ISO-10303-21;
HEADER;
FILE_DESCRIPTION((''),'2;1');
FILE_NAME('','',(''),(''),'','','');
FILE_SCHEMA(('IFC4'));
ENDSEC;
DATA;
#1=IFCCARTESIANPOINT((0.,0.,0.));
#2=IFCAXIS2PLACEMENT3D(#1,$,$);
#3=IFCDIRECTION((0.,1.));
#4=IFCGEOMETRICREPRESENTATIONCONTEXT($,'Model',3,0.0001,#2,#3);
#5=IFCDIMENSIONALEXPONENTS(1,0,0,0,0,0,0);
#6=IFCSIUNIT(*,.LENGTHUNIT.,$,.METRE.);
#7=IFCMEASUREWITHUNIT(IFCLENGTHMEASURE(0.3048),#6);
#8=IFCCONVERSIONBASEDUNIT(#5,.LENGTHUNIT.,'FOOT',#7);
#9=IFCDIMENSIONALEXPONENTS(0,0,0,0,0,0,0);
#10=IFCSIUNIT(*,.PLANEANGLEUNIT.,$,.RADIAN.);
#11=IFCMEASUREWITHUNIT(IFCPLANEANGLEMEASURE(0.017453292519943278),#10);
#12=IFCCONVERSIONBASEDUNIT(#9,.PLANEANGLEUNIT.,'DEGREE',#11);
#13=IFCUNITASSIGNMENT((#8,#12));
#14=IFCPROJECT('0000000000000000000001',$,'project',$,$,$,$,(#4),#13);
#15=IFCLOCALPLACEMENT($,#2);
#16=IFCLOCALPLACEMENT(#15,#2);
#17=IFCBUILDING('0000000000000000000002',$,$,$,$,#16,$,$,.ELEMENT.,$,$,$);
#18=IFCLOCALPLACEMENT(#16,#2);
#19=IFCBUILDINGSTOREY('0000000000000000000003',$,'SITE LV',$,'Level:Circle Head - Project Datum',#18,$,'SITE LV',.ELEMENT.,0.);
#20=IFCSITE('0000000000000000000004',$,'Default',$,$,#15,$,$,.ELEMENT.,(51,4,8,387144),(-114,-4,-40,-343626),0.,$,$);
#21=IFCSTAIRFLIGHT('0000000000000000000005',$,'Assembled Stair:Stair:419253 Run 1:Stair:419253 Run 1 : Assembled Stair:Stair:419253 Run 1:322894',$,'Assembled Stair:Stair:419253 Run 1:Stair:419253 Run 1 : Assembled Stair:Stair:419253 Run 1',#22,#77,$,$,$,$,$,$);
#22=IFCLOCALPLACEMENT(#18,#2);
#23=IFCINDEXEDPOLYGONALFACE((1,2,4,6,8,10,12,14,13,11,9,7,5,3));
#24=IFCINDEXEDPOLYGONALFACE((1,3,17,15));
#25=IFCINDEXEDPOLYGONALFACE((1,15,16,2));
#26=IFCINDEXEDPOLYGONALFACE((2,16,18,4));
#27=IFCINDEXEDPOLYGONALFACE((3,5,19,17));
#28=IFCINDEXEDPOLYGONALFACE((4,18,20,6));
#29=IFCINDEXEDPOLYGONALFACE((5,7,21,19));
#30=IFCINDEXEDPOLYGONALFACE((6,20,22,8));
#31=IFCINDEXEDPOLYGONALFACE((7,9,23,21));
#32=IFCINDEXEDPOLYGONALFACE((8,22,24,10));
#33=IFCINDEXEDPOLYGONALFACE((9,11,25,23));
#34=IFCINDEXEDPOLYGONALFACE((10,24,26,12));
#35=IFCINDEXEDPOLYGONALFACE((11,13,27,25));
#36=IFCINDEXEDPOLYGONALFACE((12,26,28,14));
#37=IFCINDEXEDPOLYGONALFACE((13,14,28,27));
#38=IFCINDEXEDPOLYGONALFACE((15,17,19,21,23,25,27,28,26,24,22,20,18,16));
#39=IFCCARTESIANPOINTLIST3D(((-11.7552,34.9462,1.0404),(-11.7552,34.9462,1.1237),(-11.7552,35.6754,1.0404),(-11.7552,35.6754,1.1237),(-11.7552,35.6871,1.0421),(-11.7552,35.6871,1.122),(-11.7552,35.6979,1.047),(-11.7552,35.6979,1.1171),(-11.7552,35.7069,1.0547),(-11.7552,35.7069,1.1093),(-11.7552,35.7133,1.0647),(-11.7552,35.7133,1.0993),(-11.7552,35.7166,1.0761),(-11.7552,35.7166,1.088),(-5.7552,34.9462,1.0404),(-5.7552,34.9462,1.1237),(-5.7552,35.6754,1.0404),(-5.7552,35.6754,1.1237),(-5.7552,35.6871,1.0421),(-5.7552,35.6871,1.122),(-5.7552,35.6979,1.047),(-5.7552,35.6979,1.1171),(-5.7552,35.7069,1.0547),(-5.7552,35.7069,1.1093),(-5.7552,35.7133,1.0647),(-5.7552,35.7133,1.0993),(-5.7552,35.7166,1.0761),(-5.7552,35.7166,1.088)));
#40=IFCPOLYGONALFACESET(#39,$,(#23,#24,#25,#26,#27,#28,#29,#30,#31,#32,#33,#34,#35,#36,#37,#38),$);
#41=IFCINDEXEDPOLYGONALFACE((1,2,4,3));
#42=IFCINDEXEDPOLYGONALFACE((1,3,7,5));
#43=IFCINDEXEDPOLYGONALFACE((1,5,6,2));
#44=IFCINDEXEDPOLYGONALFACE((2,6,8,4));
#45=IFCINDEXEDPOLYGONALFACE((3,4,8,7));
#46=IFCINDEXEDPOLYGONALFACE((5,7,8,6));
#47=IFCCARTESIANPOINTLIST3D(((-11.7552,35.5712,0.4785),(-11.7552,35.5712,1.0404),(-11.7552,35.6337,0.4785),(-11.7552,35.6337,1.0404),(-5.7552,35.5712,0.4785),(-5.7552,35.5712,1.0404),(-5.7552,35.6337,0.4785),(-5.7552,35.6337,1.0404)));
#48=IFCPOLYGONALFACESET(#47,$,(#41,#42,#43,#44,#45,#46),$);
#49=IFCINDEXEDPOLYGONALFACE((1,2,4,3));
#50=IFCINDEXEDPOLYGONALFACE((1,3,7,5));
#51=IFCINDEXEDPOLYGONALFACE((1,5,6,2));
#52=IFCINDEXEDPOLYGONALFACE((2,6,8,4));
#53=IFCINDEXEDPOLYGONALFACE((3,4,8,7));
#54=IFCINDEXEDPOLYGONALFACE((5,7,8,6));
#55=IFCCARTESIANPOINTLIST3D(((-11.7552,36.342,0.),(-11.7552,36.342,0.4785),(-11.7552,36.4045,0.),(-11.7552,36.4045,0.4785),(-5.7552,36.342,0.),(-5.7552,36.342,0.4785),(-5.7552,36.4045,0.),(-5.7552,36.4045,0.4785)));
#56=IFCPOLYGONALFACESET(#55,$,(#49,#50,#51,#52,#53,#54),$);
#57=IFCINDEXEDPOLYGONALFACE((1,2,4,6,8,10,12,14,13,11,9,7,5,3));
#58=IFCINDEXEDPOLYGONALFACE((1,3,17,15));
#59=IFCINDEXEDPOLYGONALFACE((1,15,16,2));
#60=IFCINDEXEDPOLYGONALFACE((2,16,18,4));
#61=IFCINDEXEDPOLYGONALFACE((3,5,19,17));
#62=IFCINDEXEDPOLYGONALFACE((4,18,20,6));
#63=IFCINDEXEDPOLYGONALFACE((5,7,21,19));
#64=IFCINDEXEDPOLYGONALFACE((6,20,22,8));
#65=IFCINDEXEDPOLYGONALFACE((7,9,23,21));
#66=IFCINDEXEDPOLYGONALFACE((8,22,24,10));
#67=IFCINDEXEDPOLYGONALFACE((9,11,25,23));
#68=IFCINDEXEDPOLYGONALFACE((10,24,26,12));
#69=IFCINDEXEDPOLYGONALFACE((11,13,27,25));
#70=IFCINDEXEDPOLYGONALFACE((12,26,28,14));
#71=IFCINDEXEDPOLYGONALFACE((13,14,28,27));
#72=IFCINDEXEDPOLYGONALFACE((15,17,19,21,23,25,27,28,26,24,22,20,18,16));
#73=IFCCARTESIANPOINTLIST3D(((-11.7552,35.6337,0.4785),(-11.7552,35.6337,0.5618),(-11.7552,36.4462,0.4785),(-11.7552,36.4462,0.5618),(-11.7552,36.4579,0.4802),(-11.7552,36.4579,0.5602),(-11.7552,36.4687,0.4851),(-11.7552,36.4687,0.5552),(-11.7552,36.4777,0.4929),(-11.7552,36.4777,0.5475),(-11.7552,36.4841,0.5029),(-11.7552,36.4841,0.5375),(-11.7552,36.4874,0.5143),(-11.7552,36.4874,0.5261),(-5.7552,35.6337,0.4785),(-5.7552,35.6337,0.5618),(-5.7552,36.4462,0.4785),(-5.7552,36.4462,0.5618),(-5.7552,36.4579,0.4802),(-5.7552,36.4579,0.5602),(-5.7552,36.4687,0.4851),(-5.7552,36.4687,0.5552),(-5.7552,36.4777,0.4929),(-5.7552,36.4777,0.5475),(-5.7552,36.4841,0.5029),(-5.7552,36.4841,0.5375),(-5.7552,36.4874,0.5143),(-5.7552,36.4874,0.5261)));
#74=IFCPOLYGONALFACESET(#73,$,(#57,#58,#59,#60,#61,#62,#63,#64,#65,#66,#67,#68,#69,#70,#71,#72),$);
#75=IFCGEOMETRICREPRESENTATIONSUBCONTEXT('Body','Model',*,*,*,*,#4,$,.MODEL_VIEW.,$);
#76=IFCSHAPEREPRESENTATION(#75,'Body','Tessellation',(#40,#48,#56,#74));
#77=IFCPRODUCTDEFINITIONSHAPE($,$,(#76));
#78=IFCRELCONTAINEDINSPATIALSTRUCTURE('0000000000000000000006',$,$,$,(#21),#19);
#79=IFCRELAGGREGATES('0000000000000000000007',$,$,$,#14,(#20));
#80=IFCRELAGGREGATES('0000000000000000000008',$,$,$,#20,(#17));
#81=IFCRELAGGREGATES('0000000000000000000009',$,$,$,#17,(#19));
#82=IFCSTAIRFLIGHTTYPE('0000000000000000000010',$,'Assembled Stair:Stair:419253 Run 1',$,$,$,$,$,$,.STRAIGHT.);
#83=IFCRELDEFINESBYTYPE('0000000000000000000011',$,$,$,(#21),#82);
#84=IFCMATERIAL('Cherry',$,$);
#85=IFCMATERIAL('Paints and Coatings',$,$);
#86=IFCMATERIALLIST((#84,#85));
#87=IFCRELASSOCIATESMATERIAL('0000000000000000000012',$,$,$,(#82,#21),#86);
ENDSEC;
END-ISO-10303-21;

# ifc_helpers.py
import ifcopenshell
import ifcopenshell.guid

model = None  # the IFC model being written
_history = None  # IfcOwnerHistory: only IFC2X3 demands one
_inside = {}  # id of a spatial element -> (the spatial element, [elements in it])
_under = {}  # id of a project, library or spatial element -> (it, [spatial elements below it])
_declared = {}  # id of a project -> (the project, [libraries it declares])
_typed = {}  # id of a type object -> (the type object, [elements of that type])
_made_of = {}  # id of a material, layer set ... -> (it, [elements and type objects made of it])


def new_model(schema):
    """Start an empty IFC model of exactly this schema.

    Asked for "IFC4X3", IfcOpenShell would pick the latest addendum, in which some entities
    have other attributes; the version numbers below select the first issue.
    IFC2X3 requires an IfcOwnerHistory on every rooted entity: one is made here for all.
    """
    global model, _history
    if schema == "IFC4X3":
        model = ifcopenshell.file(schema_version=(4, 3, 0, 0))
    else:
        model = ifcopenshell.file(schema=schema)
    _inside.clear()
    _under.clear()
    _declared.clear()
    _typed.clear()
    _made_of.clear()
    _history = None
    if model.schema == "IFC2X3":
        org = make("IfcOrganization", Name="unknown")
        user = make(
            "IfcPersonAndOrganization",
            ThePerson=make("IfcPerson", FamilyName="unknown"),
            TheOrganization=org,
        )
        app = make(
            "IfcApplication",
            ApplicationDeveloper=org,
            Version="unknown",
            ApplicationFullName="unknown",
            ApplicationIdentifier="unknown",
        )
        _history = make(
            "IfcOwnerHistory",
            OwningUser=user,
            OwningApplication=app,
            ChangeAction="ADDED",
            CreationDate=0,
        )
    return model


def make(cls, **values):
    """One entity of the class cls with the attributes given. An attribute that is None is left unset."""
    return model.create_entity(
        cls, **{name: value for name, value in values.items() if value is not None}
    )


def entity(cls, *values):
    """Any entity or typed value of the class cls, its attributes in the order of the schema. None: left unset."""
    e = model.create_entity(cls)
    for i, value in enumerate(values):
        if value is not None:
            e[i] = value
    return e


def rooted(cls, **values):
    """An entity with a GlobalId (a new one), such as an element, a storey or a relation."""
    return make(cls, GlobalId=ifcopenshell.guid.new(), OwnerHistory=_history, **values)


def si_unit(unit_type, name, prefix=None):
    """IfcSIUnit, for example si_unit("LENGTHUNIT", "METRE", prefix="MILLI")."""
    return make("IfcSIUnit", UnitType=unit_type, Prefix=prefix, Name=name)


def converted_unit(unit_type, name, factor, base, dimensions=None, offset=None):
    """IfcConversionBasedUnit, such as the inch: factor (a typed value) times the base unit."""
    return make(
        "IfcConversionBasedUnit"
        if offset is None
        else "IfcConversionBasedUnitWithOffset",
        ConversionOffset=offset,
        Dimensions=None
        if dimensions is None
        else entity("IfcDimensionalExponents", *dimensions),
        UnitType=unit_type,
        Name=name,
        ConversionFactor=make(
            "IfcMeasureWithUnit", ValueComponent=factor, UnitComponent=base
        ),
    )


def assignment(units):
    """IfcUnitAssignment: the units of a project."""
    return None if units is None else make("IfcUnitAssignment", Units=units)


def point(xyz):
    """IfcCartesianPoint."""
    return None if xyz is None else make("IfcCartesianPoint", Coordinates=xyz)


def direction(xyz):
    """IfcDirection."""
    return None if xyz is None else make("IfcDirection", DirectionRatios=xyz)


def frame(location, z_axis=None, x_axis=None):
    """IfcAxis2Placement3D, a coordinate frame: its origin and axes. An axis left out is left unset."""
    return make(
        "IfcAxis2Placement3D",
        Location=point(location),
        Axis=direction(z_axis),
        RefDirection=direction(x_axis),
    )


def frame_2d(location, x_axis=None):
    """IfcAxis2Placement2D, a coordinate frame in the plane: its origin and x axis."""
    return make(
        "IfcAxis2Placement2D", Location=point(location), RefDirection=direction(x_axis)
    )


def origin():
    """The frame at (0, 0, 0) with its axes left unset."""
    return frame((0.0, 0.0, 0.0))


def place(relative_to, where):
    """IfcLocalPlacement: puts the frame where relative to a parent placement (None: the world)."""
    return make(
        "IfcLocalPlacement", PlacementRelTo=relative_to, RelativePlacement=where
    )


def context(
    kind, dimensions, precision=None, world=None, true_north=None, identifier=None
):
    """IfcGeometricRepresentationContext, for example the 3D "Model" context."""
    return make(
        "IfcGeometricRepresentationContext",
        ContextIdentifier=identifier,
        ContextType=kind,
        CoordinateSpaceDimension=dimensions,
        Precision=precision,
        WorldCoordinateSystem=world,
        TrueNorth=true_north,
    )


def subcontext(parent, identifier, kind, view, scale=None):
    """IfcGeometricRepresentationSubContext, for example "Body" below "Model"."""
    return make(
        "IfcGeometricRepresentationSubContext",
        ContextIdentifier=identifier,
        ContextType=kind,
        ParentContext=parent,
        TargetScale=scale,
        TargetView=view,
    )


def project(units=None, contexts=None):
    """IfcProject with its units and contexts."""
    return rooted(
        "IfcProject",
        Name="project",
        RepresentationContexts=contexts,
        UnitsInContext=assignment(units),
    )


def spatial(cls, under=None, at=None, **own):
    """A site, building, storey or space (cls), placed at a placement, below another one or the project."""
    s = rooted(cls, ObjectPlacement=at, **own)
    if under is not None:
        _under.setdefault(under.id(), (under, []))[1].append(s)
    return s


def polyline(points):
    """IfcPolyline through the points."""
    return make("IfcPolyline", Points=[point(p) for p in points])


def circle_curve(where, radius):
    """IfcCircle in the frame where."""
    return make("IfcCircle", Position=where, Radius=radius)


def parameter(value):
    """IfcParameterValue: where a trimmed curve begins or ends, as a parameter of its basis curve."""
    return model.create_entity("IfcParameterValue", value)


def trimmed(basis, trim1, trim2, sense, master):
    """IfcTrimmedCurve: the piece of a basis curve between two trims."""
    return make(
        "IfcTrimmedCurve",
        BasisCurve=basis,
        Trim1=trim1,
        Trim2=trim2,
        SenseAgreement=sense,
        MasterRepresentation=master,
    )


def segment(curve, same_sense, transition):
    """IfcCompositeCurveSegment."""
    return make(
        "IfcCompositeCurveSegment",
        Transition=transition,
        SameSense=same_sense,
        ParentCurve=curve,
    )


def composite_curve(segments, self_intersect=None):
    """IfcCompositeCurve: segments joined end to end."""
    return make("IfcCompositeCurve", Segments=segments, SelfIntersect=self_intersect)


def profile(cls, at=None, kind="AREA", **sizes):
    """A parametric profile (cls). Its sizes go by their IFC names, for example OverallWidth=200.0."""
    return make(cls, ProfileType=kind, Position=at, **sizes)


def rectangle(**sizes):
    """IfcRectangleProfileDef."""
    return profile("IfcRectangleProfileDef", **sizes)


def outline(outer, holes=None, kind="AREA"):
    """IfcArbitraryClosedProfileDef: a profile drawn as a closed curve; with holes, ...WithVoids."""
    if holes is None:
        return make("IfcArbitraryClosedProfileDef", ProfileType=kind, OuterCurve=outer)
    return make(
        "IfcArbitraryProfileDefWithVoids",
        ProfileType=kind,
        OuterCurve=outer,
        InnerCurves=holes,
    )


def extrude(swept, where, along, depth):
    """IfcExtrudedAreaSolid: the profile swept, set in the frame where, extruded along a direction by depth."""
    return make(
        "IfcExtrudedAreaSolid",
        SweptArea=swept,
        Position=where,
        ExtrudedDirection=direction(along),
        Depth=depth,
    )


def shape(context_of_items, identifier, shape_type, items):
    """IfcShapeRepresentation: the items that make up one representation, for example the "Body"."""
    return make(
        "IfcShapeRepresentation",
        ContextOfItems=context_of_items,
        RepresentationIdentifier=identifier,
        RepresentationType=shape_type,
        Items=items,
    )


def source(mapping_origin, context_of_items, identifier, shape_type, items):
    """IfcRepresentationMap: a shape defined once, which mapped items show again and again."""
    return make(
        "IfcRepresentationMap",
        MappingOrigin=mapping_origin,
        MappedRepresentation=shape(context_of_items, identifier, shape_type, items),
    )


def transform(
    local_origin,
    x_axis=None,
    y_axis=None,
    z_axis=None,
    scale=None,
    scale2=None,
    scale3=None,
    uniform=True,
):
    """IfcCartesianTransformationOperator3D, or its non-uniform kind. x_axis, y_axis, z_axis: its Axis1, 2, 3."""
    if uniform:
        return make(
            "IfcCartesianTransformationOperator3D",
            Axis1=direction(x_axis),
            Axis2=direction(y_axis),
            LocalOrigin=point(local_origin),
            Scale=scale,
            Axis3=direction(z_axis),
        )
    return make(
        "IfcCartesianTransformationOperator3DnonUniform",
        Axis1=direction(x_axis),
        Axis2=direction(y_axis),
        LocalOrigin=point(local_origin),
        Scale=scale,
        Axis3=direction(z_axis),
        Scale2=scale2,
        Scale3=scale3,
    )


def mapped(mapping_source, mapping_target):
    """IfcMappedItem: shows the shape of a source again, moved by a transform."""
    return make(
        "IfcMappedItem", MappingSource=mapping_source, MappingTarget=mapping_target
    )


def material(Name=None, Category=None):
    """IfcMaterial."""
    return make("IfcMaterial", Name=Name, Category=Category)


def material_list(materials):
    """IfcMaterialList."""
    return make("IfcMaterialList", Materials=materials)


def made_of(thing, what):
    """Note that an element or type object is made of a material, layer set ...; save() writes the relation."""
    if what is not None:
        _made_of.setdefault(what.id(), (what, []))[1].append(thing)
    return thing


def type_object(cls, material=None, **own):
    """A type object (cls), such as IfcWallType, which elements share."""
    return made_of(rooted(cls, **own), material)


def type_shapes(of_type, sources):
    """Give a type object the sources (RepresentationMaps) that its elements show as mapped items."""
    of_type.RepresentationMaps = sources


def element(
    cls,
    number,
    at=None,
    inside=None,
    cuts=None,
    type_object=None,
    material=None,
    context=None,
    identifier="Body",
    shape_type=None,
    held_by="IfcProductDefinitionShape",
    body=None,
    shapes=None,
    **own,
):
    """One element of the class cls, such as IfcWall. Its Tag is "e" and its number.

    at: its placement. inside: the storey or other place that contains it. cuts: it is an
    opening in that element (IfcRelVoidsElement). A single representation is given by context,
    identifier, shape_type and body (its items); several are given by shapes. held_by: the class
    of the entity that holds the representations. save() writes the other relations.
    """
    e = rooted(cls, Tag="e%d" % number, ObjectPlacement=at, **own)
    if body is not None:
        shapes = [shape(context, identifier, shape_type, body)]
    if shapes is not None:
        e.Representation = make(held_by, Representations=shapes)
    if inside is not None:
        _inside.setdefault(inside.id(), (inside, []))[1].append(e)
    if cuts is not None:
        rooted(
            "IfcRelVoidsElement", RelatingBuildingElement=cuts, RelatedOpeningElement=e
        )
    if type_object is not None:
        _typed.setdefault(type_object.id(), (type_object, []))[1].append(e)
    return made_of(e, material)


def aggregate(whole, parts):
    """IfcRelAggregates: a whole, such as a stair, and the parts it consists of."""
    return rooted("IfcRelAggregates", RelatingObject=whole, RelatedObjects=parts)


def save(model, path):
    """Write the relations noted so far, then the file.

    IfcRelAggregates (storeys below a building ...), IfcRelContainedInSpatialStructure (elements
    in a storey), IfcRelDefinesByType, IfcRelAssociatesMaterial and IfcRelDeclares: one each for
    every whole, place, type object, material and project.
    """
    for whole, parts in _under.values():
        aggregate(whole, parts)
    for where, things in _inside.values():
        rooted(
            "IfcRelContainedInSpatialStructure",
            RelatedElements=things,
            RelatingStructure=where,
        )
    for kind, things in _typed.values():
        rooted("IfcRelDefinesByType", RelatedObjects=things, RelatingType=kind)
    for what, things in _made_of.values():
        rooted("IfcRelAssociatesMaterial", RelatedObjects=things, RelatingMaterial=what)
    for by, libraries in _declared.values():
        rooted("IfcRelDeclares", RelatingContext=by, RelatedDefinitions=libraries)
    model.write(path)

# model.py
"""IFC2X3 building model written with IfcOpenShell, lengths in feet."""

from ifc_helpers import new_model, entity, si_unit, converted_unit, direction, frame, frame_2d, origin, place, context, subcontext, project, spatial, polyline, circle_curve, parameter, trimmed, segment, composite_curve, rectangle, outline, extrude, source, transform, mapped, material, material_list, type_object, type_shapes, element, save


model = new_model("IFC2X3")

# Units and contexts
model_context = context("Model", 3, precision=0.0001, world=origin(), true_north=direction((0.0, 1.0)))
body_context = subcontext(model_context, "Body", "Model", "MODEL_VIEW")
ifc_project = project(units=[converted_unit("LENGTHUNIT", "FOOT", entity("IfcLengthMeasure", 0.3048), si_unit("LENGTHUNIT", "METRE"), dimensions=[1, 0, 0, 0, 0, 0, 0]), converted_unit("PLANEANGLEUNIT", "DEGREE", entity("IfcPlaneAngleMeasure", 0.017453292519943278), si_unit("PLANEANGLEUNIT", "RADIAN"), dimensions=[0, 0, 0, 0, 0, 0, 0])], contexts=[model_context])

# Site, building, storey
site_placement = place(None, origin())
site = spatial("IfcSite", under=ifc_project, at=site_placement, Name="Default", CompositionType="ELEMENT", RefLatitude=(51, 4, 8, 387144), RefLongitude=(-114, -4, -40, -343626), RefElevation=0.0)
building_placement = place(site_placement, origin())
building = spatial("IfcBuilding", under=site, at=building_placement, CompositionType="ELEMENT")
storey_placement = place(building_placement, origin())
storey = spatial("IfcBuildingStorey", under=building, at=storey_placement, Name="SITE LV", ObjectType="Level:Circle Head - Project Datum", LongName="SITE LV", CompositionType="ELEMENT", Elevation=0.0)

# Shared definitions
ifc_material_1 = material(Name="Paints and Coatings")

# Stair flight
ifc_material_2 = material(Name="Cherry")
ifc_material_list = material_list([ifc_material_2, ifc_material_1])
stair_flight_type = type_object("IfcStairFlightType", Name="Assembled Stair:Stair:419253 Run 1", PredefinedType="STRAIGHT", material=ifc_material_list)
shared_shape_1 = source(origin(), body_context, "Body", "SweptSolid", [
    extrude(outline(composite_curve([segment(polyline([(-0.3646, -0.0417), (0.3646, -0.0417)]), True, "CONTINUOUS"), segment(trimmed(circle_curve(frame_2d((0.3646, 0.0), x_axis=(-1.0, 0.0)), 0.0417), [parameter(90.0)], [parameter(270.0)], True, "PARAMETER"), True, "CONTINUOUS"), segment(polyline([(0.3646, 0.0417), (-0.3646, 0.0417)]), True, "CONTINUOUS"), segment(polyline([(-0.3646, 0.0417), (-0.3646, -0.0417)]), True, "CONTINUOUS")], self_intersect=False)), frame((-11.7552, 35.3108, 1.082), z_axis=(1.0, 0.0, 0.0), x_axis=(0.0, 1.0, 0.0)), (0.0, 0.0, 1.0), 6.0),
    extrude(rectangle(XDim=0.0625, YDim=6.0, at=frame_2d((0.0, 0.0), x_axis=(1.0, 0.0))), frame((-8.7552, 35.6024, 0.4785), z_axis=(0.0, 0.0, 1.0), x_axis=(0.0, 1.0, 0.0)), (0.0, 0.0, 1.0), 0.5618),
    extrude(rectangle(XDim=0.0625, YDim=6.0, at=frame_2d((0.0, 0.0), x_axis=(1.0, 0.0))), frame((-8.7552, 36.3733, 0.0), z_axis=(0.0, 0.0, 1.0), x_axis=(0.0, 1.0, 0.0)), (0.0, 0.0, 1.0), 0.4785),
    extrude(outline(composite_curve([segment(polyline([(-0.4063, -0.0417), (0.4063, -0.0417)]), True, "CONTINUOUS"), segment(trimmed(circle_curve(frame_2d((0.4063, 0.0), x_axis=(-1.0, 0.0)), 0.0417), [parameter(90.0)], [parameter(270.0)], True, "PARAMETER"), True, "CONTINUOUS"), segment(polyline([(0.4063, 0.0417), (-0.4063, 0.0417)]), True, "CONTINUOUS"), segment(polyline([(-0.4063, 0.0417), (-0.4063, -0.0417)]), True, "CONTINUOUS")], self_intersect=False)), frame((-11.7552, 36.0399, 0.5202), z_axis=(1.0, 0.0, 0.0), x_axis=(0.0, 1.0, 0.0)), (0.0, 0.0, 1.0), 6.0),
])
type_shapes(stair_flight_type, [shared_shape_1])
stair_flight_placement = place(storey_placement, origin())
element("IfcStairFlight", 1, at=stair_flight_placement, inside=storey, type_object=stair_flight_type, material=ifc_material_list, Name="Assembled Stair:Stair:419253 Run 1:Stair:419253 Run 1 : Assembled Stair:Stair:419253 Run 1:322894", ObjectType="Assembled Stair:Stair:419253 Run 1:Stair:419253 Run 1 : Assembled Stair:Stair:419253 Run 1", context=body_context, shape_type="MappedRepresentation", body=[
    mapped(shared_shape_1, transform((0.0, 0.0, 0.0), scale=1.0)),
])

save(model, "model.ifc")
